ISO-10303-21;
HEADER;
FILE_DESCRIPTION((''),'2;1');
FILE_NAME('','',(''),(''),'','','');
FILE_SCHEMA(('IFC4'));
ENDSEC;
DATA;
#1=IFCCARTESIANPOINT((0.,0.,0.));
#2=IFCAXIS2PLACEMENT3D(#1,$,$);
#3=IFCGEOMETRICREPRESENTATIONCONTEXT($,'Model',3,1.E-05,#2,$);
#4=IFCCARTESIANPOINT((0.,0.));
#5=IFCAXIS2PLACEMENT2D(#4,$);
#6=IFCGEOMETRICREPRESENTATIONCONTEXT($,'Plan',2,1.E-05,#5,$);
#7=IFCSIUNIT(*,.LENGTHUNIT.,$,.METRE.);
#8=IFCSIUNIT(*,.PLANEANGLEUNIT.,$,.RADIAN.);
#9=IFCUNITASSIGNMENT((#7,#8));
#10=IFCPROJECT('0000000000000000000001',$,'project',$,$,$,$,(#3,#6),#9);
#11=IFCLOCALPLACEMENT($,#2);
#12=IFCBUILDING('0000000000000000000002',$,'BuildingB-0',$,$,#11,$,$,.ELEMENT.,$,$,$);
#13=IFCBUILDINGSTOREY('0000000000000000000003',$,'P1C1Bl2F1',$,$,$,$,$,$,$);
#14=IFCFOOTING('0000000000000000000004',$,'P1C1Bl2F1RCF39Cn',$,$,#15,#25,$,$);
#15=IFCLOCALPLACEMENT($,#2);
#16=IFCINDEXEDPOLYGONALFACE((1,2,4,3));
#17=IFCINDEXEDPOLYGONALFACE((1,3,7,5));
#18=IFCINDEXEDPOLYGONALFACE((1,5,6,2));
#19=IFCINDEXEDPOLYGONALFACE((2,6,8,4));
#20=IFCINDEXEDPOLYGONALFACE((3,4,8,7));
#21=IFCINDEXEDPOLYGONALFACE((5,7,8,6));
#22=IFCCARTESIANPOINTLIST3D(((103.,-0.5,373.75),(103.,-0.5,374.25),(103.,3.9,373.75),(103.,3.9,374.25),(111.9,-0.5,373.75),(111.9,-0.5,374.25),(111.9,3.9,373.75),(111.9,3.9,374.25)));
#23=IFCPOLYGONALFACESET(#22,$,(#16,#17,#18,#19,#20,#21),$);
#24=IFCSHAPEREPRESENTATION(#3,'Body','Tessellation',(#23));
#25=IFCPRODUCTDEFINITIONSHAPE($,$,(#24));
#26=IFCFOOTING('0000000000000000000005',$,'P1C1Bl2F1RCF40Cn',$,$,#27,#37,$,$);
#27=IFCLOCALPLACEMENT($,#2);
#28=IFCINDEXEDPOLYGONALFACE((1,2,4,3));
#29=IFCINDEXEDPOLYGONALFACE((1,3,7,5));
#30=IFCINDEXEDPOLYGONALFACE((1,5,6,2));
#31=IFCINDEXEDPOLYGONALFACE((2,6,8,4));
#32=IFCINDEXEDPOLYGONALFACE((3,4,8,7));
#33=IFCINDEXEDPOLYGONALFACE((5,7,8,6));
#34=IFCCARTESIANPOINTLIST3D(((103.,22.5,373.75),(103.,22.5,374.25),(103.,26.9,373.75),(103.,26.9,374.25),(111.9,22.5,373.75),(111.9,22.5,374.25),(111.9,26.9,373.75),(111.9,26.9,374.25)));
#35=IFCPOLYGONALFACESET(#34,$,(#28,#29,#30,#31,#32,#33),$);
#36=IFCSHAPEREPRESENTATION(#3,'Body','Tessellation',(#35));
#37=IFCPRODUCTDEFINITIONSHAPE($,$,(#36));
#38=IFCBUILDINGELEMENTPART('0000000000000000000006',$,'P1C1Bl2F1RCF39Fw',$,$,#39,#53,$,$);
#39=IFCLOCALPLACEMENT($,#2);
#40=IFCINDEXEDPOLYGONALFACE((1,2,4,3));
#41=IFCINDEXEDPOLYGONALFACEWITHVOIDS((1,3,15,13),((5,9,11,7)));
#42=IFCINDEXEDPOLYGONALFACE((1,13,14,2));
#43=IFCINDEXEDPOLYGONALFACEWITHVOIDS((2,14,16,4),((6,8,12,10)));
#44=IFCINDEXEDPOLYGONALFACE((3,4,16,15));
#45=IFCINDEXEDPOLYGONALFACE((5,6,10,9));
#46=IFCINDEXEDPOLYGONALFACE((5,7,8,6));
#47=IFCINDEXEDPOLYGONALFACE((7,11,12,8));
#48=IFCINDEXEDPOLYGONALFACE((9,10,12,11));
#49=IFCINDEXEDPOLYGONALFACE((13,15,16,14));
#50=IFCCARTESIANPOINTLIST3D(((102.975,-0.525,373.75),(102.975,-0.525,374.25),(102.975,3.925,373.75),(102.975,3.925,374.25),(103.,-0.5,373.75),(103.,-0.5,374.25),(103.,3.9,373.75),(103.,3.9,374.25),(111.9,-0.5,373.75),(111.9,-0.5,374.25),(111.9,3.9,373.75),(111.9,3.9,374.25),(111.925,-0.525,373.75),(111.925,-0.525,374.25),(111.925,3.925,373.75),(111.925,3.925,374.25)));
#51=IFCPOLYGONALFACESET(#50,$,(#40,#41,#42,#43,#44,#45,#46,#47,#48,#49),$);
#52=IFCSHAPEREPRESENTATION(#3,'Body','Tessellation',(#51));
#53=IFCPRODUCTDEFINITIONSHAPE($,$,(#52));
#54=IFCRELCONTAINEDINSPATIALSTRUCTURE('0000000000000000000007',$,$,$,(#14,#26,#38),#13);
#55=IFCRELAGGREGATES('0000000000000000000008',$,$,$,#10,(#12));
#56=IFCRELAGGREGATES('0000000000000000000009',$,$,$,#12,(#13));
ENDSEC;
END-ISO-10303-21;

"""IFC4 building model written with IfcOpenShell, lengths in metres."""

from ifc_helpers import new_model, si_unit, origin, origin_2d, place, context, project, spatial, polyline, outline, extrude, element, save


model = new_model("IFC4")

# Units and contexts
model_context = context("Model", 3, precision=1e-05, world=origin())
plan_context = context("Plan", 2, precision=1e-05, world=origin_2d())
ifc_project = project(units=[si_unit("LENGTHUNIT", "METRE"), si_unit("PLANEANGLEUNIT", "RADIAN")], contexts=[model_context, plan_context])

# Building, storey
building_placement = place(None, origin())
building = spatial("IfcBuilding", under=ifc_project, at=building_placement, Name="BuildingB-0", CompositionType="ELEMENT")
storey = spatial("IfcBuildingStorey", under=building, Name="P1C1Bl2F1")

# Footings
element("IfcFooting", 1, inside=storey, Name="P1C1Bl2F1RCF39Cn", context=model_context, shape_type="SweptSolid", body=[
    extrude(outline(polyline([(111.9, 3.9, 373.75), (103.0, 3.9, 373.75), (103.0, -0.5, 373.75), (111.9, -0.5, 373.75), (111.9, 3.9, 373.75)])), None, (0.0, 0.0, 1.0), 0.5),
])
element("IfcFooting", 2, inside=storey, Name="P1C1Bl2F1RCF40Cn", context=model_context, shape_type="SweptSolid", body=[
    extrude(outline(polyline([(111.9, 26.9, 373.75), (103.0, 26.9, 373.75), (103.0, 22.5, 373.75), (111.9, 22.5, 373.75), (111.9, 26.9, 373.75)])), None, (0.0, 0.0, 1.0), 0.5),
])

# Building element part, opening
building_element_part = element("IfcBuildingElementPart", 3, inside=storey, Name="P1C1Bl2F1RCF39Fw", context=model_context, shape_type="SweptSolid", body=[
    extrude(outline(polyline([(111.925, 3.925, 373.75), (102.975, 3.925, 373.75), (102.975, -0.525, 373.75), (111.925, -0.525, 373.75), (111.925, 3.925, 373.75)])), None, (0.0, 0.0, 1.0), 0.5),
])
element("IfcOpeningElement", 4, inside=storey, cuts=building_element_part, context=model_context, shape_type="SweptSolid", body=[
    extrude(outline(polyline([(111.9, 3.9, 373.75), (103.0, 3.9, 373.75), (103.0, -0.5, 373.75), (111.9, -0.5, 373.75), (111.9, 3.9, 373.75)])), None, (0.0, 0.0, 1.0), 0.5),
])

save(model, "model.ifc")
